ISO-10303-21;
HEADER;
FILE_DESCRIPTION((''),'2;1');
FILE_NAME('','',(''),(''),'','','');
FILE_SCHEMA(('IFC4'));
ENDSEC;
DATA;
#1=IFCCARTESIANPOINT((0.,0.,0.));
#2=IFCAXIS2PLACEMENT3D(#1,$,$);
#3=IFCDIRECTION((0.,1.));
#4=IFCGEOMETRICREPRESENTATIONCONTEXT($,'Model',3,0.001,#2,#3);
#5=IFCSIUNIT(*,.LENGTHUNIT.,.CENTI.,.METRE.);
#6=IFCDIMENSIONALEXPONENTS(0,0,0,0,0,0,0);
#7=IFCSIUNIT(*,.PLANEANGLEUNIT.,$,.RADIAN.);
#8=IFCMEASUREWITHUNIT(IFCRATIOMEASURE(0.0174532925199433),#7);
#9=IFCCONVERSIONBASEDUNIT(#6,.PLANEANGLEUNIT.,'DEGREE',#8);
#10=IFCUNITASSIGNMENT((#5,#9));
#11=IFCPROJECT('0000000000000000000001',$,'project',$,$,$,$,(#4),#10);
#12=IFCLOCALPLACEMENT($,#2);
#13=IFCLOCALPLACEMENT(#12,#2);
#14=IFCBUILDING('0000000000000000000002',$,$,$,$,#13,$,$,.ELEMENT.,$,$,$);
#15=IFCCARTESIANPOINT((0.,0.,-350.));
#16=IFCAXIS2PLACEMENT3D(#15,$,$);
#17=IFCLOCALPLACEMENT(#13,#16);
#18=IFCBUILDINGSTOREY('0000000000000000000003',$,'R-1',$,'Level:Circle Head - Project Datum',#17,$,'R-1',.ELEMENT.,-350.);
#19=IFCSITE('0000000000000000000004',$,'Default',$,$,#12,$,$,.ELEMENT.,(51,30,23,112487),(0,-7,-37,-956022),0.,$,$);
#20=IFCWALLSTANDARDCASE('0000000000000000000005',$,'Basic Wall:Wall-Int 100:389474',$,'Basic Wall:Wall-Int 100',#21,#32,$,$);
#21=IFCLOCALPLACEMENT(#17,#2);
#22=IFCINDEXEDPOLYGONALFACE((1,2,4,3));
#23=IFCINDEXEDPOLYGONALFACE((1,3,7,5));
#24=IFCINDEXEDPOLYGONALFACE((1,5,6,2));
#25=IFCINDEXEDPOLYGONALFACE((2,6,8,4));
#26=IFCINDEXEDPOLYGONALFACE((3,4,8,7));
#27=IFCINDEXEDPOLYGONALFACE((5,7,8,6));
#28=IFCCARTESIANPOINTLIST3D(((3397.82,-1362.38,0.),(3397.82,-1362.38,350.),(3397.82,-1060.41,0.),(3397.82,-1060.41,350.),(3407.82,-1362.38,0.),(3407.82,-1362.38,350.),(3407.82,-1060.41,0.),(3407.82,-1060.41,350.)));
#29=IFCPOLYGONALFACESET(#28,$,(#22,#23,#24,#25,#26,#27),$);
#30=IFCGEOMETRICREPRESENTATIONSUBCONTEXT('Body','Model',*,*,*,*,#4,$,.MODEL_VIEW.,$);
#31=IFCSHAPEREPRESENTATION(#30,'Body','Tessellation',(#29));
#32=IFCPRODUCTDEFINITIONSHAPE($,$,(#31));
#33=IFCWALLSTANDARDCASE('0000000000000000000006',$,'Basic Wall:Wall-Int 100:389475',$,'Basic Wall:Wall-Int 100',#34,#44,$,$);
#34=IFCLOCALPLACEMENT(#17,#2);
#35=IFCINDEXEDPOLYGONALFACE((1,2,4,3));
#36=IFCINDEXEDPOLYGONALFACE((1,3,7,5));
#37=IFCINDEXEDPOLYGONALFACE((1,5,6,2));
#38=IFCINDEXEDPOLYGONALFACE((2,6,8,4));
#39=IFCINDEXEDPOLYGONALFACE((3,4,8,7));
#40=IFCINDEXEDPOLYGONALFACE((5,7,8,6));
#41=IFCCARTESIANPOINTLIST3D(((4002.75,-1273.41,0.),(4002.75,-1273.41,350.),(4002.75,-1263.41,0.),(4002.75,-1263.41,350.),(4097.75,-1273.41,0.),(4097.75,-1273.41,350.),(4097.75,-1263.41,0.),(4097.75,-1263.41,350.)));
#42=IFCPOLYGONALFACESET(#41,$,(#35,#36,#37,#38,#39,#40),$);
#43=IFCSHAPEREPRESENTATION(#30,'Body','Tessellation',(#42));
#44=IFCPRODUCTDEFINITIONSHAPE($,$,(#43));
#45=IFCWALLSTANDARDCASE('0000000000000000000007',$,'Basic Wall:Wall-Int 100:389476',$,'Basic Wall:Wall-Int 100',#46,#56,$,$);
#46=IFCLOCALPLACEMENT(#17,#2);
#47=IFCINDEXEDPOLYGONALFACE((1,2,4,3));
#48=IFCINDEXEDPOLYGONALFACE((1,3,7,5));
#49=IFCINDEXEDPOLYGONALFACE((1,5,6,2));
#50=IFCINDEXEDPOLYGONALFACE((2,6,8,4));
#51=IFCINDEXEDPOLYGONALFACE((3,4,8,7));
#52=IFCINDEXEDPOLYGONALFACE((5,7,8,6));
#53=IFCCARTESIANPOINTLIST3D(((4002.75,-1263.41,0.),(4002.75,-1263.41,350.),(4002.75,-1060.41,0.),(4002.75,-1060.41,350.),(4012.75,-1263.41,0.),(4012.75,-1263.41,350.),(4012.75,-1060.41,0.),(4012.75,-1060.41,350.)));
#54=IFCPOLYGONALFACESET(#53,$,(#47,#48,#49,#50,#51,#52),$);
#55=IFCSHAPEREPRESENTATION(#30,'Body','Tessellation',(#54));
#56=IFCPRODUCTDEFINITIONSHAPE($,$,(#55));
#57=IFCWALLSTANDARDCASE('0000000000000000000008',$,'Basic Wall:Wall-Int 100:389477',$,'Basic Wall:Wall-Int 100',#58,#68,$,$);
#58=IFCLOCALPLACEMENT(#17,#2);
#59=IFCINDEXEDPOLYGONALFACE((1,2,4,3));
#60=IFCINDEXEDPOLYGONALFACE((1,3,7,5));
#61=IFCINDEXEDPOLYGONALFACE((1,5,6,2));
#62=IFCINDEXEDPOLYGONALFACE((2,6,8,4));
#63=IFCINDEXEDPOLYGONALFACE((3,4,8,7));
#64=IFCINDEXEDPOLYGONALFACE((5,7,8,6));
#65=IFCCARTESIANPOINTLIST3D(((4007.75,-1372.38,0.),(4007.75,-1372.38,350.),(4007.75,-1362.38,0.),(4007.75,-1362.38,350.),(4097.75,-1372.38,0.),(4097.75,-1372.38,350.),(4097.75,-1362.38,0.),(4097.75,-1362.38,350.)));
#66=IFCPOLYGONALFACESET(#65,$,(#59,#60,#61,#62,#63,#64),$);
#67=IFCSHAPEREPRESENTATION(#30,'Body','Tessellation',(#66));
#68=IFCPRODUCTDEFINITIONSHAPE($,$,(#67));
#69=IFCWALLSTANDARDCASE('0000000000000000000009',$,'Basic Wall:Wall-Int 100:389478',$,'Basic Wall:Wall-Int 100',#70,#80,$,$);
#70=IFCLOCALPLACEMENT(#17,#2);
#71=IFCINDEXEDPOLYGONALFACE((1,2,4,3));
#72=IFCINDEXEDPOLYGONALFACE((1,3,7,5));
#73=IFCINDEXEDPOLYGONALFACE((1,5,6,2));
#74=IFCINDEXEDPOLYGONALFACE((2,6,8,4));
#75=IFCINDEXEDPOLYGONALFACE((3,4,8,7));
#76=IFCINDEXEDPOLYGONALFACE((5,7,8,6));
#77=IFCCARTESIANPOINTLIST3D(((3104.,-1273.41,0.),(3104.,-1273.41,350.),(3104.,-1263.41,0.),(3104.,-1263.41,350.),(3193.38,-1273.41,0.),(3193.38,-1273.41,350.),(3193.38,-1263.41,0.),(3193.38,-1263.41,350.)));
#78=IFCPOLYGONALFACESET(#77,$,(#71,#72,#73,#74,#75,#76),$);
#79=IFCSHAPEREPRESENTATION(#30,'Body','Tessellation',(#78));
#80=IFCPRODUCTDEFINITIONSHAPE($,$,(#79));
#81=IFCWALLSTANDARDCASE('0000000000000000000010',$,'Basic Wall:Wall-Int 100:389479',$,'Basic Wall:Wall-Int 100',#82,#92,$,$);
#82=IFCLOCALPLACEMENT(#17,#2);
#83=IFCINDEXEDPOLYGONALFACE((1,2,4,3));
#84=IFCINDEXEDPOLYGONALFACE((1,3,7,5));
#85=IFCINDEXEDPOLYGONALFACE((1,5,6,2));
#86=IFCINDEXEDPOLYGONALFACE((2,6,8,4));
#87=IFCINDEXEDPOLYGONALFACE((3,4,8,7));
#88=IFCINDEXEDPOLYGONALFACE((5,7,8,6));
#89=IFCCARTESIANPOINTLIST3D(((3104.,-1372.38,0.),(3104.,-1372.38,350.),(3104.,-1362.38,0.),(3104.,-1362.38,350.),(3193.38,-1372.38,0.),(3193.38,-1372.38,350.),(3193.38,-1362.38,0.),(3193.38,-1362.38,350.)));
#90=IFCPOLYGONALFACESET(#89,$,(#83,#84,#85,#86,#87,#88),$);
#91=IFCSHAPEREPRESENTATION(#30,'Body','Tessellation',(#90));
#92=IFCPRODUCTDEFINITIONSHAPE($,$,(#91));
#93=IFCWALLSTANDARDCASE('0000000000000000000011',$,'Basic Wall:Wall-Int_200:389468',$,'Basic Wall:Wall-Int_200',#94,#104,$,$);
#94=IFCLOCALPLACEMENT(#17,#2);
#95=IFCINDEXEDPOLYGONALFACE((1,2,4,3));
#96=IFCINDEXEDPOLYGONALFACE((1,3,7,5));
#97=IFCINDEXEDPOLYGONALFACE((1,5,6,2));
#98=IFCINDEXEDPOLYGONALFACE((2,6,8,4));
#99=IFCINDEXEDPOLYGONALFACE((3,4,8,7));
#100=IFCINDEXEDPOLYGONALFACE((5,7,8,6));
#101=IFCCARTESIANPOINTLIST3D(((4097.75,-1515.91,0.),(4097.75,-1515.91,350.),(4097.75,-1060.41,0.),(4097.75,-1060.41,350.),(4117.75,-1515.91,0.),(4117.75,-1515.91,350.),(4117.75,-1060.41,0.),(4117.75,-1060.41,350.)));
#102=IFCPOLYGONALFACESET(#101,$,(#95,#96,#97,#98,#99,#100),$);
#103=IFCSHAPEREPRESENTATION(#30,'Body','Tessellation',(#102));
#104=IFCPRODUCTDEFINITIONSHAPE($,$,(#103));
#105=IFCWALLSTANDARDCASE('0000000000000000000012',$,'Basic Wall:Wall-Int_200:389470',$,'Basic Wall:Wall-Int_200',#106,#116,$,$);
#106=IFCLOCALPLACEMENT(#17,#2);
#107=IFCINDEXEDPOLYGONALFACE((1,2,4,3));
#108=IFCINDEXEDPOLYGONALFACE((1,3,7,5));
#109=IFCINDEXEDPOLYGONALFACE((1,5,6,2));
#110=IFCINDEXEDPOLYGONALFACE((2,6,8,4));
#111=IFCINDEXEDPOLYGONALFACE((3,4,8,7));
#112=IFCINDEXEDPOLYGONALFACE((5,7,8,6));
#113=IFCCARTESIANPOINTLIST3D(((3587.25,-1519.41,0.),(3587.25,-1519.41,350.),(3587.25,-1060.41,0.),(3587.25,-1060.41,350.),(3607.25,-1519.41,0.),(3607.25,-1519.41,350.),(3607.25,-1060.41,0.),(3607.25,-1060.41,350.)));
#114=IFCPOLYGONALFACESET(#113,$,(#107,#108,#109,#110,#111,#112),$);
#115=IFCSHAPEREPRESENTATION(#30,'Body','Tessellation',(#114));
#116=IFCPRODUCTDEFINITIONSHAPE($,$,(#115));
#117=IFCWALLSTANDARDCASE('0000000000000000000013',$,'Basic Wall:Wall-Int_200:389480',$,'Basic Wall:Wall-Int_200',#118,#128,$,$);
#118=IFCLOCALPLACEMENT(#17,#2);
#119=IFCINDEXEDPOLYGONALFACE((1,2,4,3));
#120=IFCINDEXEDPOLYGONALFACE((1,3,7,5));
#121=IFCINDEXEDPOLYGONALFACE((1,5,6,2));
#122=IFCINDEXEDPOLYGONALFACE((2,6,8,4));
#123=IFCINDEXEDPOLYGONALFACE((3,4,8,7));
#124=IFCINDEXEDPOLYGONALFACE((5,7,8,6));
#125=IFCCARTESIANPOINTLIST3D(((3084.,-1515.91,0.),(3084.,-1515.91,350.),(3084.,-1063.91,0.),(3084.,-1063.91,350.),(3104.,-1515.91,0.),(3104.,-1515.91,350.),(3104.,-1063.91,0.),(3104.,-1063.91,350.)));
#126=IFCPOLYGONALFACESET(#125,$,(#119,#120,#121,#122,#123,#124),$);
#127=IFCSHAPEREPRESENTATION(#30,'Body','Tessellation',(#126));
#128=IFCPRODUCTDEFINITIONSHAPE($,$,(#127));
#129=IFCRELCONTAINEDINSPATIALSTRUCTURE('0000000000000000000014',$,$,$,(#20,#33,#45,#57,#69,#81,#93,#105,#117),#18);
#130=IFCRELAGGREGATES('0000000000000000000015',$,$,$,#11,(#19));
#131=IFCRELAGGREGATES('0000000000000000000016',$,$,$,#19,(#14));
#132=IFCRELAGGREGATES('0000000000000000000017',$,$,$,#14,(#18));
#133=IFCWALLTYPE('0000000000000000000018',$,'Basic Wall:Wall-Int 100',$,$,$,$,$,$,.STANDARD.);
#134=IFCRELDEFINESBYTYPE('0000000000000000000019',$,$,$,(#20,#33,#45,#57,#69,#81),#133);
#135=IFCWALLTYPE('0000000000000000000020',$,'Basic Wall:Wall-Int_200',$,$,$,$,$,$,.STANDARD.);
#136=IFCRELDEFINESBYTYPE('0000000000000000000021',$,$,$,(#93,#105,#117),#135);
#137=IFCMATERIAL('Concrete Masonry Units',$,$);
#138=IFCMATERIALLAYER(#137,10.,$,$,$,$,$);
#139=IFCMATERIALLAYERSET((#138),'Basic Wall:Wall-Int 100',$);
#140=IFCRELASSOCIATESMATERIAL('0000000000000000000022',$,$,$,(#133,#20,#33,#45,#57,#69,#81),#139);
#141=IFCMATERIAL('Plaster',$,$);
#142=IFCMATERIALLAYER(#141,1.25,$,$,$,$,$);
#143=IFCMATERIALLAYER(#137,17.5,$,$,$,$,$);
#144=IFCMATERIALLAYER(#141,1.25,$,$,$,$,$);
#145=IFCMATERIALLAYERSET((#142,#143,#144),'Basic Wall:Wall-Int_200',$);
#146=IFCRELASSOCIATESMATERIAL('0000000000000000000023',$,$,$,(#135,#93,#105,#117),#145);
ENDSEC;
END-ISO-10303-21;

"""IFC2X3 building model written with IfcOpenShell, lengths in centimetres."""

from ifc_helpers import new_model, entity, si_unit, converted_unit, direction, frame, frame_2d, origin, place, context, subcontext, project, spatial, rectangle, extrude, material, layer, layer_set, layer_usage, type_object, element, save


model = new_model("IFC2X3")

# Units and contexts
model_context = context("Model", 3, precision=0.001, world=origin(), true_north=direction((0.0, 1.0)))
body_context = subcontext(model_context, "Body", "Model", "MODEL_VIEW")
ifc_project = project(units=[si_unit("LENGTHUNIT", "METRE", prefix="CENTI"), converted_unit("PLANEANGLEUNIT", "DEGREE", entity("IfcRatioMeasure", 0.0174532925199433), si_unit("PLANEANGLEUNIT", "RADIAN"), dimensions=[0, 0, 0, 0, 0, 0, 0])], contexts=[model_context])

# Site, building, storey
site_placement = place(None, origin())
site = spatial("IfcSite", under=ifc_project, at=site_placement, Name="Default", CompositionType="ELEMENT", RefLatitude=(51, 30, 23, 112487), RefLongitude=(0, -7, -37, -956022), RefElevation=0.0)
building_placement = place(site_placement, origin())
building = spatial("IfcBuilding", under=site, at=building_placement, CompositionType="ELEMENT")
storey_placement = place(building_placement, frame((0.0, 0.0, -350.0)))
storey = spatial("IfcBuildingStorey", under=building, at=storey_placement, Name="R-1", ObjectType="Level:Circle Head - Project Datum", LongName="R-1", CompositionType="ELEMENT", Elevation=-350.0)

# Shared definitions
ifc_material_1 = material(Name="Concrete Masonry Units")

# Shared definitions
ifc_layer_1 = layer(ifc_material_1, 10.0)
ifc_layer_set_1 = layer_set([ifc_layer_1], Name="Basic Wall:Wall-Int 100")
wall_type_1 = type_object("IfcWallType", Name="Basic Wall:Wall-Int 100", PredefinedType="STANDARD", material=ifc_layer_set_1)

# Walls
ifc_layer_usage_1 = layer_usage(ifc_layer_set_1, "AXIS2", "POSITIVE", -5.0)
wall_1_placement = place(storey_placement, frame((3402.82, -1362.38, 0.0), z_axis=(0.0, 0.0, 1.0), x_axis=(0.0, 1.0, 0.0)))
element("IfcWallStandardCase", 1, at=wall_1_placement, inside=storey, type_object=wall_type_1, material=ifc_layer_usage_1, Name="Basic Wall:Wall-Int 100:389474", ObjectType="Basic Wall:Wall-Int 100", context=body_context, shape_type="SweptSolid", body=[
    extrude(rectangle(XDim=301.97, YDim=10.0, at=frame_2d((150.98, 0.0), x_axis=(-1.0, 0.0))), origin(), (0.0, 0.0, 1.0), 350.0),
])
ifc_layer_usage_2 = layer_usage(ifc_layer_set_1, "AXIS2", "POSITIVE", -5.0)
wall_2_placement = place(storey_placement, frame((4097.75, -1268.41, 0.0), z_axis=(0.0, 0.0, 1.0), x_axis=(-1.0, 0.0, 0.0)))
element("IfcWallStandardCase", 2, at=wall_2_placement, inside=storey, type_object=wall_type_1, material=ifc_layer_usage_2, Name="Basic Wall:Wall-Int 100:389475", ObjectType="Basic Wall:Wall-Int 100", context=body_context, shape_type="SweptSolid", body=[
    extrude(rectangle(XDim=95.0, YDim=10.0, at=frame_2d((47.5, 0.0), x_axis=(-1.0, 0.0))), origin(), (0.0, 0.0, 1.0), 350.0),
])
ifc_layer_usage_3 = layer_usage(ifc_layer_set_1, "AXIS2", "POSITIVE", -5.0)
wall_3_placement = place(storey_placement, frame((4007.75, -1060.41, 0.0), z_axis=(0.0, 0.0, 1.0), x_axis=(0.0, -1.0, 0.0)))
element("IfcWallStandardCase", 3, at=wall_3_placement, inside=storey, type_object=wall_type_1, material=ifc_layer_usage_3, Name="Basic Wall:Wall-Int 100:389476", ObjectType="Basic Wall:Wall-Int 100", context=body_context, shape_type="SweptSolid", body=[
    extrude(rectangle(XDim=203.0, YDim=10.0, at=frame_2d((101.5, 0.0), x_axis=(-1.0, 0.0))), origin(), (0.0, 0.0, 1.0), 350.0),
])
ifc_layer_usage_4 = layer_usage(ifc_layer_set_1, "AXIS2", "POSITIVE", -5.0)
wall_4_placement = place(storey_placement, frame((4097.75, -1367.38, 0.0), z_axis=(0.0, 0.0, 1.0), x_axis=(-1.0, 0.0, 0.0)))
element("IfcWallStandardCase", 4, at=wall_4_placement, inside=storey, type_object=wall_type_1, material=ifc_layer_usage_4, Name="Basic Wall:Wall-Int 100:389477", ObjectType="Basic Wall:Wall-Int 100", context=body_context, shape_type="SweptSolid", body=[
    extrude(rectangle(XDim=90.0, YDim=10.0, at=frame_2d((45.0, 0.0), x_axis=(-1.0, 0.0))), origin(), (0.0, 0.0, 1.0), 350.0),
])
ifc_layer_usage_5 = layer_usage(ifc_layer_set_1, "AXIS2", "POSITIVE", -5.0)
wall_5_placement = place(storey_placement, frame((3104.0, -1268.41, 0.0)))
element("IfcWallStandardCase", 5, at=wall_5_placement, inside=storey, type_object=wall_type_1, material=ifc_layer_usage_5, Name="Basic Wall:Wall-Int 100:389478", ObjectType="Basic Wall:Wall-Int 100", context=body_context, shape_type="SweptSolid", body=[
    extrude(rectangle(XDim=89.38, YDim=10.0, at=frame_2d((44.69, 0.0), x_axis=(-1.0, 0.0))), origin(), (0.0, 0.0, 1.0), 350.0),
])
ifc_layer_usage_6 = layer_usage(ifc_layer_set_1, "AXIS2", "POSITIVE", -5.0)
wall_6_placement = place(storey_placement, frame((3104.0, -1367.38, 0.0)))
element("IfcWallStandardCase", 6, at=wall_6_placement, inside=storey, type_object=wall_type_1, material=ifc_layer_usage_6, Name="Basic Wall:Wall-Int 100:389479", ObjectType="Basic Wall:Wall-Int 100", context=body_context, shape_type="SweptSolid", body=[
    extrude(rectangle(XDim=89.38, YDim=10.0, at=frame_2d((44.69, 0.0), x_axis=(-1.0, 0.0))), origin(), (0.0, 0.0, 1.0), 350.0),
])
ifc_material_2 = material(Name="Plaster")
ifc_layer_2 = layer(ifc_material_2, 1.25)
ifc_layer_3 = layer(ifc_material_1, 17.5)
ifc_layer_4 = layer(ifc_material_2, 1.25)
ifc_layer_set_2 = layer_set([ifc_layer_2, ifc_layer_3, ifc_layer_4], Name="Basic Wall:Wall-Int_200")
ifc_layer_usage_7 = layer_usage(ifc_layer_set_2, "AXIS2", "NEGATIVE", 10.0)
wall_type_2 = type_object("IfcWallType", Name="Basic Wall:Wall-Int_200", PredefinedType="STANDARD", material=ifc_layer_set_2)
wall_7_placement = place(storey_placement, frame((4107.75, -1515.91, 0.0), z_axis=(0.0, 0.0, 1.0), x_axis=(0.0, 1.0, 0.0)))
element("IfcWallStandardCase", 7, at=wall_7_placement, inside=storey, type_object=wall_type_2, material=ifc_layer_usage_7, Name="Basic Wall:Wall-Int_200:389468", ObjectType="Basic Wall:Wall-Int_200", context=body_context, shape_type="SweptSolid", body=[
    extrude(rectangle(XDim=455.5, YDim=20.0, at=frame_2d((227.75, 0.0), x_axis=(-1.0, 0.0))), origin(), (0.0, 0.0, 1.0), 350.0),
])
ifc_layer_usage_8 = layer_usage(ifc_layer_set_2, "AXIS2", "POSITIVE", -10.0)
wall_8_placement = place(storey_placement, frame((3597.25, -1519.41, 0.0), z_axis=(0.0, 0.0, 1.0), x_axis=(0.0, 1.0, 0.0)))
element("IfcWallStandardCase", 8, at=wall_8_placement, inside=storey, type_object=wall_type_2, material=ifc_layer_usage_8, Name="Basic Wall:Wall-Int_200:389470", ObjectType="Basic Wall:Wall-Int_200", context=body_context, shape_type="SweptSolid", body=[
    extrude(rectangle(XDim=459.0, YDim=20.0, at=frame_2d((229.5, 0.0), x_axis=(-1.0, 0.0))), origin(), (0.0, 0.0, 1.0), 350.0),
])
ifc_layer_usage_9 = layer_usage(ifc_layer_set_2, "AXIS2", "POSITIVE", -10.0)
wall_9_placement = place(storey_placement, frame((3094.0, -1515.91, 0.0), z_axis=(0.0, 0.0, 1.0), x_axis=(0.0, 1.0, 0.0)))
element("IfcWallStandardCase", 9, at=wall_9_placement, inside=storey, type_object=wall_type_2, material=ifc_layer_usage_9, Name="Basic Wall:Wall-Int_200:389480", ObjectType="Basic Wall:Wall-Int_200", context=body_context, shape_type="SweptSolid", body=[
    extrude(rectangle(XDim=452.0, YDim=20.0, at=frame_2d((226.0, 0.0), x_axis=(-1.0, 0.0))), origin(), (0.0, 0.0, 1.0), 350.0),
])

save(model, "model.ifc")
